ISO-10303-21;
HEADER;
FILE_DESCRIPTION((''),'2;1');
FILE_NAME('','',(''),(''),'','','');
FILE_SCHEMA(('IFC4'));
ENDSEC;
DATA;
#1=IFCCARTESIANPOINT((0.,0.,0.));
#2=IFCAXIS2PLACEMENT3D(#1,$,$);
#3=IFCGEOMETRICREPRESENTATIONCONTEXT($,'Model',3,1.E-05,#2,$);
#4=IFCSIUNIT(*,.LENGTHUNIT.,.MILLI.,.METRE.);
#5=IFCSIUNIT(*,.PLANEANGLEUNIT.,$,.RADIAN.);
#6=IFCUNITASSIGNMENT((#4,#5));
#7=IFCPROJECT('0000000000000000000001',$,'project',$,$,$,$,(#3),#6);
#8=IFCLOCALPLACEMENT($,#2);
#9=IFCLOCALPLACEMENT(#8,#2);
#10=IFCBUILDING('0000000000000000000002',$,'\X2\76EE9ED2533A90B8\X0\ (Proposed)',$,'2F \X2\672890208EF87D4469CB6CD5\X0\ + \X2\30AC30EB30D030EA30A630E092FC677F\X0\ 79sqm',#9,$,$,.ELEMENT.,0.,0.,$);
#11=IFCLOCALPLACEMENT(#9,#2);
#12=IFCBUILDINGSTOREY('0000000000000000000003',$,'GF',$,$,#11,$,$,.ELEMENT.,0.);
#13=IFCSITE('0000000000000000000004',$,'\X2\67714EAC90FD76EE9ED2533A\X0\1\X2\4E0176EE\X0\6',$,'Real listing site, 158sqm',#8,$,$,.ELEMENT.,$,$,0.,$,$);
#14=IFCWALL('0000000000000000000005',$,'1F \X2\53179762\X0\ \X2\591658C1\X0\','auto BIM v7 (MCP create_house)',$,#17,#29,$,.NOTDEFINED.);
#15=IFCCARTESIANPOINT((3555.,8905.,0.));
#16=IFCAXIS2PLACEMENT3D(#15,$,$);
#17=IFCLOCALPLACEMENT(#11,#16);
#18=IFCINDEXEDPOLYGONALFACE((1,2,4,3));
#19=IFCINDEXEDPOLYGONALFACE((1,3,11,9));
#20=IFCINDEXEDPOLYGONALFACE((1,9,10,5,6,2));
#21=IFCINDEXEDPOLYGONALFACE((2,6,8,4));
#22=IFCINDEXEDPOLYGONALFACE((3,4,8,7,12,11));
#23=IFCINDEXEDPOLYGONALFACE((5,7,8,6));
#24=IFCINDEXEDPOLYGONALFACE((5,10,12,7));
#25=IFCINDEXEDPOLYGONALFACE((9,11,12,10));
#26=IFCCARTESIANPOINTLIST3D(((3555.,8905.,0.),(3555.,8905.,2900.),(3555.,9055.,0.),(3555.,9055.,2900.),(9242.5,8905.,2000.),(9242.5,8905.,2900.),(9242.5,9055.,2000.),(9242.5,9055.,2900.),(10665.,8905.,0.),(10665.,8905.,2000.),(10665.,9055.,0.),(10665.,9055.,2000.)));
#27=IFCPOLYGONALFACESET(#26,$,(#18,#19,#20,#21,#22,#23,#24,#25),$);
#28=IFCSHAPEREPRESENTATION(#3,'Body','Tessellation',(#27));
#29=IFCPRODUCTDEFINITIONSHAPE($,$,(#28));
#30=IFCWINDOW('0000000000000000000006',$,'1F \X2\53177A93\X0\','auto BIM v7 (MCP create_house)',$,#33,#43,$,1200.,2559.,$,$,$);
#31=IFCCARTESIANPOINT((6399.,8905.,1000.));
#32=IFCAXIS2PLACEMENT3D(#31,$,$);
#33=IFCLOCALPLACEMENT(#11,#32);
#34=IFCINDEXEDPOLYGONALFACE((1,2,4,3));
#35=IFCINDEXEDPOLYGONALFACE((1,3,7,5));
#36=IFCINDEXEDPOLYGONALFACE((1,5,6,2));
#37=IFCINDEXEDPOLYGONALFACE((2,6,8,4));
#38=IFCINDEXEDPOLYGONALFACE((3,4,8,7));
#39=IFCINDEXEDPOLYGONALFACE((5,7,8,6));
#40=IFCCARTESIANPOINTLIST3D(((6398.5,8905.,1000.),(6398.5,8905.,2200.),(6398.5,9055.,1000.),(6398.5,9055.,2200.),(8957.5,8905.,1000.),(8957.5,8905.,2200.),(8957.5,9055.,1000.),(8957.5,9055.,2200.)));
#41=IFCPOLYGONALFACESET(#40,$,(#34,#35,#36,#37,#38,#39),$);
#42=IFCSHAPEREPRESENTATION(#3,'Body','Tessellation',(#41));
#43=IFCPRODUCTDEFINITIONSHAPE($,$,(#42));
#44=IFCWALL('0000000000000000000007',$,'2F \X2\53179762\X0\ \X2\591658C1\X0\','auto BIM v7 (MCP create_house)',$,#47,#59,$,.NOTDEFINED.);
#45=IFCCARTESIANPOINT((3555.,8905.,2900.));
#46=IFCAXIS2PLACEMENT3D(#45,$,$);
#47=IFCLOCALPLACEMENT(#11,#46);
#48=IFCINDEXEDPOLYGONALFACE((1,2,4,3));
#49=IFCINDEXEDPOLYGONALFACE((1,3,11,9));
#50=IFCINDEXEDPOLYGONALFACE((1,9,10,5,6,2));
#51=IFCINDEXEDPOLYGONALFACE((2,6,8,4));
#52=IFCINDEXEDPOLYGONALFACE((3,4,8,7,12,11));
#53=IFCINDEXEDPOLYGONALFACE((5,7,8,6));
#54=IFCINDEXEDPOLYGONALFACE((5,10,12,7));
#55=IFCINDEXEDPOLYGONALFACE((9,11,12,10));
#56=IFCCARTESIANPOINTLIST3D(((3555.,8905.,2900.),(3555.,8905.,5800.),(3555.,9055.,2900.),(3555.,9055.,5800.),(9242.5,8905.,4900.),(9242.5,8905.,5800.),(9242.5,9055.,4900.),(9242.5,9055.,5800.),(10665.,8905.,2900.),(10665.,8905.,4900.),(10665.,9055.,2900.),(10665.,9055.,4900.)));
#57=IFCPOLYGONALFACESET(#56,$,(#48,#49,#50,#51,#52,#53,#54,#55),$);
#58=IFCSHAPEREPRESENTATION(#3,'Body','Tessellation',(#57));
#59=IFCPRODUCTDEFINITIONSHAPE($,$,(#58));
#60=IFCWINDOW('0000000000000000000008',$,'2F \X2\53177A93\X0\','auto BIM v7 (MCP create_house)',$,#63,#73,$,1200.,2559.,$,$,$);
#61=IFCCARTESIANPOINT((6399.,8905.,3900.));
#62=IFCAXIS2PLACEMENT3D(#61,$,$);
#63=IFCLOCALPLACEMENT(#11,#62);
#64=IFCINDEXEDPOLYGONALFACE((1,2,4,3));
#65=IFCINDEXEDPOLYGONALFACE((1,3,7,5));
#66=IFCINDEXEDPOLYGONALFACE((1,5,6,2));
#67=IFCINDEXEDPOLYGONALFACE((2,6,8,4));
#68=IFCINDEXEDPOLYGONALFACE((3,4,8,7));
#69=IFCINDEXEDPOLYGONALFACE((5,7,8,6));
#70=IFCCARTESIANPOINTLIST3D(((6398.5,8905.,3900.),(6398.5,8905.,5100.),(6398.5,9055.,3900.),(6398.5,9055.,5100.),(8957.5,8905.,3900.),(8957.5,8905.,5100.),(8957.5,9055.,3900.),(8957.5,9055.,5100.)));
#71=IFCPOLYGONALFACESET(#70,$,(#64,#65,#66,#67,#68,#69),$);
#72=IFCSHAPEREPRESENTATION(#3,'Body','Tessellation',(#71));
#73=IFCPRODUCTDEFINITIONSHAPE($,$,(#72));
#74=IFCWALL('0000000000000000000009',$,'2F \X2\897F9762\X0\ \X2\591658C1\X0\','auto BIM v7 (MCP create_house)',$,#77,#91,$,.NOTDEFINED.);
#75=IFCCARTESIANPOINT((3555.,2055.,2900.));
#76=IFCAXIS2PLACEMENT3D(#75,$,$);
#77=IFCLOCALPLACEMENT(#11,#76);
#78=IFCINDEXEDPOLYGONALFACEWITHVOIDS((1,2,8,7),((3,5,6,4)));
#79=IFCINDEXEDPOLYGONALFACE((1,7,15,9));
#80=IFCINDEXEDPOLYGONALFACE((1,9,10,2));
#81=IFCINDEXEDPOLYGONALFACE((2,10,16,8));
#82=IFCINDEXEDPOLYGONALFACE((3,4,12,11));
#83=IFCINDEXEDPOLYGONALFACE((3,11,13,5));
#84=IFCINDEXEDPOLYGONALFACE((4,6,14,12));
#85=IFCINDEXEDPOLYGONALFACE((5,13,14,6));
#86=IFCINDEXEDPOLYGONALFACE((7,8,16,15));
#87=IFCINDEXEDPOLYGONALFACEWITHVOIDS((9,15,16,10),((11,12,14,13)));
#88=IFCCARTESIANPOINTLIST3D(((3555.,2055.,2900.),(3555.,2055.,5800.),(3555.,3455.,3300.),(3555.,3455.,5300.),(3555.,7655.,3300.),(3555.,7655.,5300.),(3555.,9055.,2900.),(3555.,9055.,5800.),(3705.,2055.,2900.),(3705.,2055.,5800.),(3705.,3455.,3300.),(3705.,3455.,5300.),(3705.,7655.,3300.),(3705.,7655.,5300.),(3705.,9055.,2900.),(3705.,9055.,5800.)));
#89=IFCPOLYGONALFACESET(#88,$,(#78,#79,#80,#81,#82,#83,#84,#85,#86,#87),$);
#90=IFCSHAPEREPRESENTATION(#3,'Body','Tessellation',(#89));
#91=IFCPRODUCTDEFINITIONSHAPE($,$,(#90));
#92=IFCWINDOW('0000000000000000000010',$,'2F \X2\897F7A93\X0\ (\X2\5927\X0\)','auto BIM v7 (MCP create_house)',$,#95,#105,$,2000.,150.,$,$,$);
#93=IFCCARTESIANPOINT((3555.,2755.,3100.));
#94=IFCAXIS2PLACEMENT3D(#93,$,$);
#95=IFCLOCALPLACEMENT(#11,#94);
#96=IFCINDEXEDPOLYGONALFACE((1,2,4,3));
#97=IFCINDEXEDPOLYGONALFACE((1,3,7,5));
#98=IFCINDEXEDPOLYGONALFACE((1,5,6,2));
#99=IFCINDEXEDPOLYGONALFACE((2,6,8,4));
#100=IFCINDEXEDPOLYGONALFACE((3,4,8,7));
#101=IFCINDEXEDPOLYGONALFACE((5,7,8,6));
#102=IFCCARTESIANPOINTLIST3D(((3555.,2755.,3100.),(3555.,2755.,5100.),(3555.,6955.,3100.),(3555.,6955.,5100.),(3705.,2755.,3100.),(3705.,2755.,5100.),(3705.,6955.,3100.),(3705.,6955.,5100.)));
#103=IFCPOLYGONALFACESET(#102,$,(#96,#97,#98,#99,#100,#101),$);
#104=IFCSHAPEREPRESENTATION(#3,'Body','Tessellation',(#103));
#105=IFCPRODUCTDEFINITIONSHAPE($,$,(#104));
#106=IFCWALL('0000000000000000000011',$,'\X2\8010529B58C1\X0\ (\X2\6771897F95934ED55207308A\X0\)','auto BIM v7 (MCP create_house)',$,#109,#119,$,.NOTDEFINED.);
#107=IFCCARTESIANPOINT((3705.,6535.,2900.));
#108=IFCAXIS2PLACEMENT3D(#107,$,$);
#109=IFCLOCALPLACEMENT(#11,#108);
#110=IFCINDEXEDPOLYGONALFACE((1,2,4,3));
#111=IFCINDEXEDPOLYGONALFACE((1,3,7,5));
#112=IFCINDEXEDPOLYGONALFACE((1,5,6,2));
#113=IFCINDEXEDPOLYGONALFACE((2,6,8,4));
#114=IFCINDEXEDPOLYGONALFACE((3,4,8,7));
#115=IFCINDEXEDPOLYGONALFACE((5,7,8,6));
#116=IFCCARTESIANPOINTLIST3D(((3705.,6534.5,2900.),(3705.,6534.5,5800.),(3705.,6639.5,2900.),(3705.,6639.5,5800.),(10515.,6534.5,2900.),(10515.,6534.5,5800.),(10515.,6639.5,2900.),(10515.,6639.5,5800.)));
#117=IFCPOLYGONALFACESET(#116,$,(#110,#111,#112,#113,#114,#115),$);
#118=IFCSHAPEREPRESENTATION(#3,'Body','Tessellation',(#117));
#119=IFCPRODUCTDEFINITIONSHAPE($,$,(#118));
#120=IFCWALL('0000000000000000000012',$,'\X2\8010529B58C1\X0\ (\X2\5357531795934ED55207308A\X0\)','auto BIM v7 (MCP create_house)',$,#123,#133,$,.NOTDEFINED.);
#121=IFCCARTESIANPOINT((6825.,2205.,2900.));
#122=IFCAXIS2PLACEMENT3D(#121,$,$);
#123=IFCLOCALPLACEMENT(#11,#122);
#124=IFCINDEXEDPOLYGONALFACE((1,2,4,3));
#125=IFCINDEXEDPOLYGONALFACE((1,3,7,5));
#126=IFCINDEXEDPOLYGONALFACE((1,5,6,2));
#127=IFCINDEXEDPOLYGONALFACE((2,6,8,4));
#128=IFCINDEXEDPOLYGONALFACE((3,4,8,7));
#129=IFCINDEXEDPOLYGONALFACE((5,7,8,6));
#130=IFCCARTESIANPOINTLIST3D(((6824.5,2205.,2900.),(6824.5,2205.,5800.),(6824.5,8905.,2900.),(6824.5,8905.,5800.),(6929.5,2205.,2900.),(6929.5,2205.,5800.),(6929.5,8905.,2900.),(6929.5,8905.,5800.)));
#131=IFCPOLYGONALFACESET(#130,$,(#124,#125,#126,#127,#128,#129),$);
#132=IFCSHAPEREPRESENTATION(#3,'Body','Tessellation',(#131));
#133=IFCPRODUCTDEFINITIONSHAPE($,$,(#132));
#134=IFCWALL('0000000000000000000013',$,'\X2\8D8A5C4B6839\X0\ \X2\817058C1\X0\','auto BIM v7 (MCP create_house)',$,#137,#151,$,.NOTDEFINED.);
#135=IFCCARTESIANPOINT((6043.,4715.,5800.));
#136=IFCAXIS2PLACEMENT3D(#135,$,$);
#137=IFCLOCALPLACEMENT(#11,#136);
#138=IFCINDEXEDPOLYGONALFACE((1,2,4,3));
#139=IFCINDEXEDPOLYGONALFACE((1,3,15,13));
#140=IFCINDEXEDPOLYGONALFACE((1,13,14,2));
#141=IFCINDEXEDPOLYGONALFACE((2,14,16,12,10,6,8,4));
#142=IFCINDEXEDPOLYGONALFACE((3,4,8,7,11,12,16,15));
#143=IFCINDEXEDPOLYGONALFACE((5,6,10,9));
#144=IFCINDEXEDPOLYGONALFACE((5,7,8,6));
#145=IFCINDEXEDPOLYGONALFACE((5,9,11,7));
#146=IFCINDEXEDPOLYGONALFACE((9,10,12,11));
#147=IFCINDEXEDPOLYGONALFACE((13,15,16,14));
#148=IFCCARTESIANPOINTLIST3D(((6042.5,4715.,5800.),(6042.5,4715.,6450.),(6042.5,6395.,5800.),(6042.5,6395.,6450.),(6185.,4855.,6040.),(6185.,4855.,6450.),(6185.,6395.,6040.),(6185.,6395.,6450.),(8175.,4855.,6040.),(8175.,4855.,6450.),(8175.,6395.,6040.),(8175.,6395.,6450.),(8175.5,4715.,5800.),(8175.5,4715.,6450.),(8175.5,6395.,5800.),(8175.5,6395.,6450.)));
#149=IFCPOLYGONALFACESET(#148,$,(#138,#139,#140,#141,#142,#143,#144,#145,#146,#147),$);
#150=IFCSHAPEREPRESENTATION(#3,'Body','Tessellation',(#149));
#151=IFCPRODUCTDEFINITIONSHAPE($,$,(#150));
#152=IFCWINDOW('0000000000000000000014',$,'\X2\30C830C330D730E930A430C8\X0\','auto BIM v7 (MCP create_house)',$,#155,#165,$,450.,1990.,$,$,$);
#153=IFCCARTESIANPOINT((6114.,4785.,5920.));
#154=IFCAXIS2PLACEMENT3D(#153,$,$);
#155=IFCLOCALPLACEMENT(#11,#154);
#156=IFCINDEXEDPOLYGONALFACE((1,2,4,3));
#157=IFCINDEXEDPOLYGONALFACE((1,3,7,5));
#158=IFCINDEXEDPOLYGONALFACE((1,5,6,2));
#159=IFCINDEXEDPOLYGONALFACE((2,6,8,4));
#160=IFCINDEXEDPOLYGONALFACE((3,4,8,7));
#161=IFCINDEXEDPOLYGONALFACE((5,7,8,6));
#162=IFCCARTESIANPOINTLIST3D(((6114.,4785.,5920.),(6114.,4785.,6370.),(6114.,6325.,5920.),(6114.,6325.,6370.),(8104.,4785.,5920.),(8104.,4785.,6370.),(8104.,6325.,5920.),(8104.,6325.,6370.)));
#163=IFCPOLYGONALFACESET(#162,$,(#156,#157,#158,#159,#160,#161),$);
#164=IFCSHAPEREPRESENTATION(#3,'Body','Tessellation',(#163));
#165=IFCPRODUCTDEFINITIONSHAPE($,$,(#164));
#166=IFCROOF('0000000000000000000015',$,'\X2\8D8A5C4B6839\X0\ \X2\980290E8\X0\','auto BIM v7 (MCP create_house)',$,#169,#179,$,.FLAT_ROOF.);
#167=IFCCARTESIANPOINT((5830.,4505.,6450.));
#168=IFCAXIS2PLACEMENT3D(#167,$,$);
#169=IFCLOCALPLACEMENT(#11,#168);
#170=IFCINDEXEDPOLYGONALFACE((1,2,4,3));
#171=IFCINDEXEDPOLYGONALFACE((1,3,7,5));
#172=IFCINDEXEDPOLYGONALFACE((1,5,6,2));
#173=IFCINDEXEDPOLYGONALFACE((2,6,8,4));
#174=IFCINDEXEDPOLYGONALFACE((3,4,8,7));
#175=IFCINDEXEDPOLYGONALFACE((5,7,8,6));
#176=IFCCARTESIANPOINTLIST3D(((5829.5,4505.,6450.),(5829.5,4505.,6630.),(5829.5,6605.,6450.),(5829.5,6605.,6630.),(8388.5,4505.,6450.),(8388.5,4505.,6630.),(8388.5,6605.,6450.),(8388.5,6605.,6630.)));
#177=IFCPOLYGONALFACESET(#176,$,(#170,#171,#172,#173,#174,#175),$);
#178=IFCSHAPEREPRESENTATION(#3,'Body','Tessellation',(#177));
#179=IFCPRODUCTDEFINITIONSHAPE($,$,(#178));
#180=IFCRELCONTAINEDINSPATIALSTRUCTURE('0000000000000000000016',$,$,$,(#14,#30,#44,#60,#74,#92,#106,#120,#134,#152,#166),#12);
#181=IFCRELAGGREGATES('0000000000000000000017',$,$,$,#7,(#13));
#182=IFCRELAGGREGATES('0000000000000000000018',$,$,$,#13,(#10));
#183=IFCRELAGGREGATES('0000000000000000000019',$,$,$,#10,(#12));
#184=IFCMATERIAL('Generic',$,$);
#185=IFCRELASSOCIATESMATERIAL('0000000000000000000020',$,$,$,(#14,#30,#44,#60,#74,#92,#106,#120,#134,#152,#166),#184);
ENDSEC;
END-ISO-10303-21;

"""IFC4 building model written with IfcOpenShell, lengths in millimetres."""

from ifc_helpers import new_model, si_unit, frame, frame_2d, origin, place, context, project, spatial, rectangle, extrude, material, element, fill, save


model = new_model("IFC4")

# Units and contexts
model_context = context("Model", 3, precision=1e-05, world=origin())
ifc_project = project(units=[si_unit("LENGTHUNIT", "METRE", prefix="MILLI"), si_unit("PLANEANGLEUNIT", "RADIAN")], contexts=[model_context])

# Site, building, storey
site_placement = place(None, origin())
site = spatial("IfcSite", under=ifc_project, at=site_placement, Name="東京都目黒区1丁目6", ObjectType="Real listing site, 158sqm", CompositionType="ELEMENT", RefElevation=0.0)
building_placement = place(site_placement, origin())
building = spatial("IfcBuilding", under=site, at=building_placement, Name="目黒区邸 (Proposed)", ObjectType="2F 木造軸組構法 + ガルバリウム鋼板 79sqm", CompositionType="ELEMENT", ElevationOfRefHeight=0.0, ElevationOfTerrain=0.0)
storey_placement = place(building_placement, origin())
storey = spatial("IfcBuildingStorey", under=building, at=storey_placement, Name="GF", CompositionType="ELEMENT", Elevation=0.0)

# Wall, opening, window
ifc_material = material(Name="Generic")
wall_1_placement = place(storey_placement, frame((3555.0, 8905.0, 0.0)))
wall_1 = element("IfcWall", 1, at=wall_1_placement, inside=storey, material=ifc_material, Name="1F 北面 外壁", Description="auto BIM v7 (MCP create_house)", PredefinedType="NOTDEFINED", context=model_context, shape_type="SweptSolid", body=[
    extrude(rectangle(XDim=7110.0, YDim=150.0, at=frame_2d((3555.0, 75.0))), frame((3555.0, 8905.0, 0.0)), (0.0, 0.0, 1.0), 2900.0),
])
opening_1_placement = place(storey_placement, frame((6399.0, 8905.0, 1000.0)))
opening_1 = element("IfcOpeningElement", 2, at=opening_1_placement, cuts=wall_1, PredefinedType="NOTDEFINED", context=model_context, shape_type="SweptSolid", body=[
    extrude(rectangle(XDim=2559.0, YDim=150.0, at=frame_2d((1279.0, 75.0))), frame((6399.0, 8905.0, 1000.0)), (0.0, 0.0, 1.0), 1200.0),
])
window_1_placement = place(storey_placement, frame((6399.0, 8905.0, 1000.0)))
window_1 = element("IfcWindow", 3, at=window_1_placement, inside=storey, material=ifc_material, Name="1F 北窓", Description="auto BIM v7 (MCP create_house)", OverallHeight=1200.0, OverallWidth=2559.0, context=model_context, shape_type="SweptSolid", body=[
    extrude(rectangle(XDim=2559.0, YDim=150.0, at=frame_2d((1279.0, 75.0))), frame((6399.0, 8905.0, 1000.0)), (0.0, 0.0, 1.0), 1200.0),
])
fill(opening_1, window_1)

# Walls, openings, windows
wall_2_placement = place(storey_placement, frame((3555.0, 8905.0, 2900.0)))
wall_2 = element("IfcWall", 4, at=wall_2_placement, inside=storey, material=ifc_material, Name="2F 北面 外壁", Description="auto BIM v7 (MCP create_house)", PredefinedType="NOTDEFINED", context=model_context, shape_type="SweptSolid", body=[
    extrude(rectangle(XDim=7110.0, YDim=150.0, at=frame_2d((3555.0, 75.0))), frame((3555.0, 8905.0, 2900.0)), (0.0, 0.0, 1.0), 2900.0),
])
opening_2_placement = place(storey_placement, frame((6399.0, 8905.0, 3900.0)))
opening_2 = element("IfcOpeningElement", 5, at=opening_2_placement, cuts=wall_2, PredefinedType="NOTDEFINED", context=model_context, shape_type="SweptSolid", body=[
    extrude(rectangle(XDim=2559.0, YDim=150.0, at=frame_2d((1279.0, 75.0))), frame((6399.0, 8905.0, 3900.0)), (0.0, 0.0, 1.0), 1200.0),
])
window_2_placement = place(storey_placement, frame((6399.0, 8905.0, 3900.0)))
window_2 = element("IfcWindow", 6, at=window_2_placement, inside=storey, material=ifc_material, Name="2F 北窓", Description="auto BIM v7 (MCP create_house)", OverallHeight=1200.0, OverallWidth=2559.0, context=model_context, shape_type="SweptSolid", body=[
    extrude(rectangle(XDim=2559.0, YDim=150.0, at=frame_2d((1279.0, 75.0))), frame((6399.0, 8905.0, 3900.0)), (0.0, 0.0, 1.0), 1200.0),
])
fill(opening_2, window_2)
wall_3_placement = place(storey_placement, frame((3555.0, 2055.0, 2900.0)))
wall_3 = element("IfcWall", 7, at=wall_3_placement, inside=storey, material=ifc_material, Name="2F 西面 外壁", Description="auto BIM v7 (MCP create_house)", PredefinedType="NOTDEFINED", context=model_context, shape_type="SweptSolid", body=[
    extrude(rectangle(XDim=150.0, YDim=7000.0, at=frame_2d((75.0, 3500.0))), frame((3555.0, 2055.0, 2900.0)), (0.0, 0.0, 1.0), 2900.0),
])
opening_3_placement = place(storey_placement, frame((3555.0, 2755.0, 3100.0)))
opening_3 = element("IfcOpeningElement", 8, at=opening_3_placement, cuts=wall_3, PredefinedType="NOTDEFINED", context=model_context, shape_type="SweptSolid", body=[
    extrude(rectangle(XDim=150.0, YDim=4200.0, at=frame_2d((75.0, 2100.0))), frame((3555.0, 2755.0, 3100.0)), (0.0, 0.0, 1.0), 2000.0),
])
window_3_placement = place(storey_placement, frame((3555.0, 2755.0, 3100.0)))
window_3 = element("IfcWindow", 9, at=window_3_placement, inside=storey, material=ifc_material, Name="2F 西窓 (大)", Description="auto BIM v7 (MCP create_house)", OverallHeight=2000.0, OverallWidth=150.0, context=model_context, shape_type="SweptSolid", body=[
    extrude(rectangle(XDim=150.0, YDim=4200.0, at=frame_2d((75.0, 2100.0))), frame((3555.0, 2755.0, 3100.0)), (0.0, 0.0, 1.0), 2000.0),
])
fill(opening_3, window_3)

# Walls
wall_4_placement = place(storey_placement, frame((3705.0, 6535.0, 2900.0)))
element("IfcWall", 10, at=wall_4_placement, inside=storey, material=ifc_material, Name="耐力壁 (東西間仕切り)", Description="auto BIM v7 (MCP create_house)", PredefinedType="NOTDEFINED", context=model_context, shape_type="SweptSolid", body=[
    extrude(rectangle(XDim=6810.0, YDim=105.0, at=frame_2d((3405.0, 52.0))), frame((3705.0, 6535.0, 2900.0)), (0.0, 0.0, 1.0), 2900.0),
])
wall_5_placement = place(storey_placement, frame((6825.0, 2205.0, 2900.0)))
element("IfcWall", 11, at=wall_5_placement, inside=storey, material=ifc_material, Name="耐力壁 (南北間仕切り)", Description="auto BIM v7 (MCP create_house)", PredefinedType="NOTDEFINED", context=model_context, shape_type="SweptSolid", body=[
    extrude(rectangle(XDim=105.0, YDim=6700.0, at=frame_2d((52.0, 3350.0))), frame((6825.0, 2205.0, 2900.0)), (0.0, 0.0, 1.0), 2900.0),
])

# Wall, opening, window
wall_6_placement = place(storey_placement, frame((6043.0, 4715.0, 5800.0)))
wall_6 = element("IfcWall", 12, at=wall_6_placement, inside=storey, material=ifc_material, Name="越屋根 腰壁", Description="auto BIM v7 (MCP create_house)", PredefinedType="NOTDEFINED", context=model_context, shape_type="SweptSolid", body=[
    extrude(rectangle(XDim=2133.0, YDim=1680.0, at=frame_2d((1066.0, 840.0))), frame((6043.0, 4715.0, 5800.0)), (0.0, 0.0, 1.0), 650.0),
])
opening_4_placement = place(storey_placement, frame((6114.0, 4785.0, 5920.0)))
opening_4 = element("IfcOpeningElement", 13, at=opening_4_placement, cuts=wall_6, PredefinedType="NOTDEFINED", context=model_context, shape_type="SweptSolid", body=[
    extrude(rectangle(XDim=1990.0, YDim=1540.0, at=frame_2d((995.0, 770.0))), frame((6114.0, 4785.0, 5920.0)), (0.0, 0.0, 1.0), 450.0),
])
window_4_placement = place(storey_placement, frame((6114.0, 4785.0, 5920.0)))
window_4 = element("IfcWindow", 14, at=window_4_placement, inside=storey, material=ifc_material, Name="トップライト", Description="auto BIM v7 (MCP create_house)", OverallHeight=450.0, OverallWidth=1990.0, context=model_context, shape_type="SweptSolid", body=[
    extrude(rectangle(XDim=1990.0, YDim=1540.0, at=frame_2d((995.0, 770.0))), frame((6114.0, 4785.0, 5920.0)), (0.0, 0.0, 1.0), 450.0),
])
fill(opening_4, window_4)

# Roof
roof_placement = place(storey_placement, frame((5830.0, 4505.0, 6450.0)))
element("IfcRoof", 15, at=roof_placement, inside=storey, material=ifc_material, Name="越屋根 頂部", Description="auto BIM v7 (MCP create_house)", PredefinedType="FLAT_ROOF", context=model_context, shape_type="SweptSolid", body=[
    extrude(rectangle(XDim=2559.0, YDim=2100.0, at=frame_2d((1279.0, 1050.0))), frame((5830.0, 4505.0, 6450.0)), (0.0, 0.0, 1.0), 180.0),
])

save(model, "model.ifc")
